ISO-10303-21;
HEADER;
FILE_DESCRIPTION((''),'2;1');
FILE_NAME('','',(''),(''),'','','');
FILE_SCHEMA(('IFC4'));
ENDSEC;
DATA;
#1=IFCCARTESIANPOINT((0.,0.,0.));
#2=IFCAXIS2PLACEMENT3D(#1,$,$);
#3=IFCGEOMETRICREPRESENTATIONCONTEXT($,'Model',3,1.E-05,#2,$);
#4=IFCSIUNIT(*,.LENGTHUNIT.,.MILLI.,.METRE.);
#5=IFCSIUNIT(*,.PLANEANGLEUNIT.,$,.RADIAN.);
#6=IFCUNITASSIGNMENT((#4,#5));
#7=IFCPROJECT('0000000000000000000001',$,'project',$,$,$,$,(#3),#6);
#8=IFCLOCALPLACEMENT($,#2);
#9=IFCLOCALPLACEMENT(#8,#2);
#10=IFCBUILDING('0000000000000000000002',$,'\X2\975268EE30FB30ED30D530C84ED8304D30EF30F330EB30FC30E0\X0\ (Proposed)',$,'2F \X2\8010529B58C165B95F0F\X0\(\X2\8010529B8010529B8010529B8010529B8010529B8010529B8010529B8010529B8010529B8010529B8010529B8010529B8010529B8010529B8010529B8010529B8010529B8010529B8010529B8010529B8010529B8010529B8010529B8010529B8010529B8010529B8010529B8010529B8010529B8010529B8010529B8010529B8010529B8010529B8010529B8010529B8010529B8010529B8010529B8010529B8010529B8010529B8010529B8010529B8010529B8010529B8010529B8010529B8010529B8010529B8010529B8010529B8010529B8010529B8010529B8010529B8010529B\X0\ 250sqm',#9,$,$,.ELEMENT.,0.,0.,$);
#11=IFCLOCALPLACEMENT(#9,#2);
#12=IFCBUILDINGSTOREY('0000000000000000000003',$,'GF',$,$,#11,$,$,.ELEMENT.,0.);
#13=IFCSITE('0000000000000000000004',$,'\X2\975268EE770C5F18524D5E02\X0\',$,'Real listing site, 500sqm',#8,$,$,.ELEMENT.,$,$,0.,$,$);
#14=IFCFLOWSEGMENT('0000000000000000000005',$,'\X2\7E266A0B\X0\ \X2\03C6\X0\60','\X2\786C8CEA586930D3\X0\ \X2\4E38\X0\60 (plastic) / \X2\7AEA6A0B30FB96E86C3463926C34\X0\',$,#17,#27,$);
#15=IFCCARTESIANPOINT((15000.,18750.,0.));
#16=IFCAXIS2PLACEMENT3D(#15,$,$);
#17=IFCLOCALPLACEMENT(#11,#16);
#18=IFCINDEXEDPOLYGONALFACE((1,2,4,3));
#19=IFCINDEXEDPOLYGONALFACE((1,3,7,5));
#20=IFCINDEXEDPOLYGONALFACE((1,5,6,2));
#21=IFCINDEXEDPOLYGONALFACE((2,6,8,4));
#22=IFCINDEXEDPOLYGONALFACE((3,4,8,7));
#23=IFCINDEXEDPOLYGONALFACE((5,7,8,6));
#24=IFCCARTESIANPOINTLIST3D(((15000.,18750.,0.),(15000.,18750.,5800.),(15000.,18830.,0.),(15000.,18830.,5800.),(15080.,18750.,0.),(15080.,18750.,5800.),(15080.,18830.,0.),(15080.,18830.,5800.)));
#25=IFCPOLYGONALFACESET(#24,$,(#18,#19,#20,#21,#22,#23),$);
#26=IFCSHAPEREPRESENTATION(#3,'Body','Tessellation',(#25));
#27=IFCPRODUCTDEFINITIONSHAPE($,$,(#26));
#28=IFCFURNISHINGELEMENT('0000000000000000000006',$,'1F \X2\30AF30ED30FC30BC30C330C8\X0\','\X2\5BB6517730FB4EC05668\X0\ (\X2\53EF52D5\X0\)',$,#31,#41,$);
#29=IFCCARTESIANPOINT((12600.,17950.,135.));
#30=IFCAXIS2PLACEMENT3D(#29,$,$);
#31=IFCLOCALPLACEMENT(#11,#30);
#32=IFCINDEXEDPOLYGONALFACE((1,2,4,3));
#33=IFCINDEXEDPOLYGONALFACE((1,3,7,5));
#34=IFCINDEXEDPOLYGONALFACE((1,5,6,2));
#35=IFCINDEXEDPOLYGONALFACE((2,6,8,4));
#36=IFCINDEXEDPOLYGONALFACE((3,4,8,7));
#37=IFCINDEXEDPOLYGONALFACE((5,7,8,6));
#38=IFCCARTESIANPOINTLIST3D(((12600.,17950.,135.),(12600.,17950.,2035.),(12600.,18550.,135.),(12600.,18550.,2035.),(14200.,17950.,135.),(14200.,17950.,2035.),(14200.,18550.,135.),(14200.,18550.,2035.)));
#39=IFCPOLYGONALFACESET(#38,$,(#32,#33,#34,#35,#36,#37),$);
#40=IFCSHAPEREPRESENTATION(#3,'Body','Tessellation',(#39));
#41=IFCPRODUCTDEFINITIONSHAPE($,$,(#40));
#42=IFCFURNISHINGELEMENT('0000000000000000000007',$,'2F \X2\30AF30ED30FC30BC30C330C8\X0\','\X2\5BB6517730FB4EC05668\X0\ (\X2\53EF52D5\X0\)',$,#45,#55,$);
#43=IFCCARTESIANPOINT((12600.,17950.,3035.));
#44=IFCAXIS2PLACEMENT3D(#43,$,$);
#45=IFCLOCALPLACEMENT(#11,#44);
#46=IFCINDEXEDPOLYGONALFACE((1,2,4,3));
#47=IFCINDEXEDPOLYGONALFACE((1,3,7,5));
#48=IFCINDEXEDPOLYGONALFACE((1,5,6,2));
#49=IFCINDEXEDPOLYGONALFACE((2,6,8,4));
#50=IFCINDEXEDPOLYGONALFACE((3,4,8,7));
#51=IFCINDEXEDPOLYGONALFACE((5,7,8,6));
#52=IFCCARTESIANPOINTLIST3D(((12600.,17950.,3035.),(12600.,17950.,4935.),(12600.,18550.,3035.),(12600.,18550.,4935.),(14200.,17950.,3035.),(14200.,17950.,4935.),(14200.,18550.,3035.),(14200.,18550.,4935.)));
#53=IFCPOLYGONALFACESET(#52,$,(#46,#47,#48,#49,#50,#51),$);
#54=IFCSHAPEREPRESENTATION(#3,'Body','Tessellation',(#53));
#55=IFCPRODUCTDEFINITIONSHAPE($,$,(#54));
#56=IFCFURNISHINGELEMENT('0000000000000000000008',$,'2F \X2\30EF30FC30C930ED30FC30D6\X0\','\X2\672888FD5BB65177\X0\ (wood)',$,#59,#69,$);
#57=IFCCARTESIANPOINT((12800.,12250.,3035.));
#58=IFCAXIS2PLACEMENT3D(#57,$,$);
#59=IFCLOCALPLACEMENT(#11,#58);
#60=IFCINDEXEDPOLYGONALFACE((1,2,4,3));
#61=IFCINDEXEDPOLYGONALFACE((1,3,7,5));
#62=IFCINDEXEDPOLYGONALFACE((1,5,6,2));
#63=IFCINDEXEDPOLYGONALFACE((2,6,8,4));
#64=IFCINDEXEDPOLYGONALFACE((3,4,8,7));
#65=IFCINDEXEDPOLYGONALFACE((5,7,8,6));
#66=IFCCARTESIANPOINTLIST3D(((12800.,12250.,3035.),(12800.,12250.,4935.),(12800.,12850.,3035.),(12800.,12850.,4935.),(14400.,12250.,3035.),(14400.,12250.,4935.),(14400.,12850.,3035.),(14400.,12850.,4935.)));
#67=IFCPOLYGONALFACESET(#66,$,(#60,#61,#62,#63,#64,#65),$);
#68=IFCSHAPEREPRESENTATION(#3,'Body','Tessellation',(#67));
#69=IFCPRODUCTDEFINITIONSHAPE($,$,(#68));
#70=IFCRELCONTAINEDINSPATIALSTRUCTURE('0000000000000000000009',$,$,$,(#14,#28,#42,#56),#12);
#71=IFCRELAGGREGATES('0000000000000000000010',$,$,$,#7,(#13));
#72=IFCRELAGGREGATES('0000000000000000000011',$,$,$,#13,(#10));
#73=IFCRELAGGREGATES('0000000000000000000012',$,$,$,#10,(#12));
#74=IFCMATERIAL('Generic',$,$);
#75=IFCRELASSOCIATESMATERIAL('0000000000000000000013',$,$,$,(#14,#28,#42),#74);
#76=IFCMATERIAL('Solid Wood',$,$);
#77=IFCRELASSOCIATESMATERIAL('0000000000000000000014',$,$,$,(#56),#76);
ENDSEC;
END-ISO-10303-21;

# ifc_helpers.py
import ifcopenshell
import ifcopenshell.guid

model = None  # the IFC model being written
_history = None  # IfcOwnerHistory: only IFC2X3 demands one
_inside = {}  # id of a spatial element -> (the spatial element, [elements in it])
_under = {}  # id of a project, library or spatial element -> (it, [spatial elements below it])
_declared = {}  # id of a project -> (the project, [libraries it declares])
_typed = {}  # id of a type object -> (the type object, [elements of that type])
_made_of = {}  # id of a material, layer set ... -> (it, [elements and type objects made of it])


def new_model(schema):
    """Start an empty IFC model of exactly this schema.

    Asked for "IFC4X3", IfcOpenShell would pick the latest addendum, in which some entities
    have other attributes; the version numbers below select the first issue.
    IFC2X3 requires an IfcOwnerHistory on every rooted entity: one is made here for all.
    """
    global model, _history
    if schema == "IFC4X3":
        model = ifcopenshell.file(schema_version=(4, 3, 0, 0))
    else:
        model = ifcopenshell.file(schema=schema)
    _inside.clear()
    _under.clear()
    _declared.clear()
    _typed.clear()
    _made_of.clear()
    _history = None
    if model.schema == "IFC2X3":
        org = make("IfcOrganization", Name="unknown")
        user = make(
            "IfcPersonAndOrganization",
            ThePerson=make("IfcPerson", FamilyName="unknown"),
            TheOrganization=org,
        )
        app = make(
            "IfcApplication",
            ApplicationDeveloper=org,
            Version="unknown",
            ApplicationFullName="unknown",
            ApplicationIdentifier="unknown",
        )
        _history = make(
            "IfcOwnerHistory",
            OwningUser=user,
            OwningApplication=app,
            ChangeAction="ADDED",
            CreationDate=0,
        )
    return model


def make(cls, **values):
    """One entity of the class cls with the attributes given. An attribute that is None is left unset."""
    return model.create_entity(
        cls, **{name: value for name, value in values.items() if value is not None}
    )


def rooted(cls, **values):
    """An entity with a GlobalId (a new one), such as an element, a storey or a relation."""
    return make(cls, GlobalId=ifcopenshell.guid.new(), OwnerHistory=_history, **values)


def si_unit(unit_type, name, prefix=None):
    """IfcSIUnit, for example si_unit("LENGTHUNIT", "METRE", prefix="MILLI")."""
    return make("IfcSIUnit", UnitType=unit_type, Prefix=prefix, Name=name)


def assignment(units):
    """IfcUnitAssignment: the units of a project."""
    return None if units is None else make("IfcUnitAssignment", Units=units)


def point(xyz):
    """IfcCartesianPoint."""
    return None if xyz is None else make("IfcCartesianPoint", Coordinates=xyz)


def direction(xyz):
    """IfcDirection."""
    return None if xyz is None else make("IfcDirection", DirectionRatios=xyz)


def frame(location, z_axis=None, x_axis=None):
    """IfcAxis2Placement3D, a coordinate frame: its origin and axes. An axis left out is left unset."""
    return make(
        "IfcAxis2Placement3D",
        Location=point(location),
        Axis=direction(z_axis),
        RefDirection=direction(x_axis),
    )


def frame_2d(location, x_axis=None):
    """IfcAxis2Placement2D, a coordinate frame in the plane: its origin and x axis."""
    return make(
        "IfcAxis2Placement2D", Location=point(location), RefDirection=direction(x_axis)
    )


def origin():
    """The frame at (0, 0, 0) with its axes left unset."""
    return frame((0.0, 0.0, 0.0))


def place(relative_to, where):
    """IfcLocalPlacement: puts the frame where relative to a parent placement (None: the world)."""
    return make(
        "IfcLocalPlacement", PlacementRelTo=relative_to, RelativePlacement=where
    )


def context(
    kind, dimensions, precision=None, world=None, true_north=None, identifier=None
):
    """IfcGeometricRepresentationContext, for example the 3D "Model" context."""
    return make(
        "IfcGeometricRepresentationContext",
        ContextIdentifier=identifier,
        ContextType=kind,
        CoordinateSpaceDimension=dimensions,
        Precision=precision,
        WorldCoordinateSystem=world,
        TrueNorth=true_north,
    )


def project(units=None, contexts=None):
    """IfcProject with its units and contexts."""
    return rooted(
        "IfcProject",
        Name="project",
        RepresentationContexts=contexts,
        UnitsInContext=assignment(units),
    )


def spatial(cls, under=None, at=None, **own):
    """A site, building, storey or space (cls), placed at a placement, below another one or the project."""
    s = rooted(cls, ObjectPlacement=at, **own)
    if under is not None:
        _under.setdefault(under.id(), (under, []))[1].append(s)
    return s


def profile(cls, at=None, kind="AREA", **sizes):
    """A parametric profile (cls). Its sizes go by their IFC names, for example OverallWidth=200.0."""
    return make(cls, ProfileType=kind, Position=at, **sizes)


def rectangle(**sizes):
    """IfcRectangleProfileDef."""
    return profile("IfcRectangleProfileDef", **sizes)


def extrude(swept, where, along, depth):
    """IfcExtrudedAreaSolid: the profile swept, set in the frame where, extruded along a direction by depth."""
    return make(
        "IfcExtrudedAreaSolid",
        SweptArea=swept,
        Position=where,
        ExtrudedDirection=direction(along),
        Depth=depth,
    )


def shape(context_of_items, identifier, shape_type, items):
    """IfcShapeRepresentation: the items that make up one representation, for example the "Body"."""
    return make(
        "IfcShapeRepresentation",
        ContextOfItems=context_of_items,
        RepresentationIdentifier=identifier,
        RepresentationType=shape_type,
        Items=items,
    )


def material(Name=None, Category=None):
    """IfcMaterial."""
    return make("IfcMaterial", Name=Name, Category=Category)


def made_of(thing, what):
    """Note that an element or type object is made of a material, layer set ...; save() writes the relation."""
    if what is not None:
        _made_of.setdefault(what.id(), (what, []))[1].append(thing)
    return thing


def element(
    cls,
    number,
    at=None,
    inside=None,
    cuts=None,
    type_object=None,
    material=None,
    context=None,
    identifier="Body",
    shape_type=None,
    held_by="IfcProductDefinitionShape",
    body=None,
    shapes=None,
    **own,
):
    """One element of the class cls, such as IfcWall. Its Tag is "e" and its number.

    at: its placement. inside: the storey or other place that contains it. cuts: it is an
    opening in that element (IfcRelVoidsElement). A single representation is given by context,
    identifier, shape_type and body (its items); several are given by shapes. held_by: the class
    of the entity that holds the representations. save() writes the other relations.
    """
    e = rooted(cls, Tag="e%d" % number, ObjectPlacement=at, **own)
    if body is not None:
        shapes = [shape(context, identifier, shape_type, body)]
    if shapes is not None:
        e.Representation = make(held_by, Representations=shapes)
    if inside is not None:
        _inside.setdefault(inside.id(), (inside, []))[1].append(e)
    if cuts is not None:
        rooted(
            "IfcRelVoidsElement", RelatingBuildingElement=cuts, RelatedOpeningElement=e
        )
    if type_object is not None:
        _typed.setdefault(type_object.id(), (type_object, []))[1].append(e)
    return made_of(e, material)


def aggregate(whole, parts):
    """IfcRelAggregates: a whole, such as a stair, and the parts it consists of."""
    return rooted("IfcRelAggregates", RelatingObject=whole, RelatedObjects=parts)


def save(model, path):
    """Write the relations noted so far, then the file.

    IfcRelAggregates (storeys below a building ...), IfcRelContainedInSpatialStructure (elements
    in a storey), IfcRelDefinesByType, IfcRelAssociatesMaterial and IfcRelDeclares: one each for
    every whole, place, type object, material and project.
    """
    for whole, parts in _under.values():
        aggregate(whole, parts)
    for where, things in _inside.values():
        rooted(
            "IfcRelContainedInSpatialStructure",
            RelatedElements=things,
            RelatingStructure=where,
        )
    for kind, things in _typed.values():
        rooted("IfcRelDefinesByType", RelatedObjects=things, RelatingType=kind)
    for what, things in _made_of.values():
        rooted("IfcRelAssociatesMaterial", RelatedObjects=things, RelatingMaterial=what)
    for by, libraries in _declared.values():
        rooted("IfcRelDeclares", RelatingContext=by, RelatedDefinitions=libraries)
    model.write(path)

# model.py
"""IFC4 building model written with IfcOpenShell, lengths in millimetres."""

from ifc_helpers import new_model, si_unit, frame, frame_2d, origin, place, context, project, spatial, rectangle, extrude, material, element, save


model = new_model("IFC4")

# Units and contexts
model_context = context("Model", 3, precision=1e-05, world=origin())
ifc_project = project(units=[si_unit("LENGTHUNIT", "METRE", prefix="MILLI"), si_unit("PLANEANGLEUNIT", "RADIAN")], contexts=[model_context])

# Site, building, storey
site_placement = place(None, origin())
site = spatial("IfcSite", under=ifc_project, at=site_placement, Name="青森県弘前市", ObjectType="Real listing site, 500sqm", CompositionType="ELEMENT", RefElevation=0.0)
building_placement = place(site_placement, origin())
building = spatial("IfcBuilding", under=site, at=building_placement, Name="青森・ロフト付きワンルーム (Proposed)", ObjectType="2F 耐力壁方式(耐力耐力耐力耐力耐力耐力耐力耐力耐力耐力耐力耐力耐力耐力耐力耐力耐力耐力耐力耐力耐力耐力耐力耐力耐力耐力耐力耐力耐力耐力耐力耐力耐力耐力耐力耐力耐力耐力耐力耐力耐力耐力耐力耐力耐力耐力耐力耐力耐力耐力耐力耐力耐力耐力耐力耐力耐力 250sqm", CompositionType="ELEMENT", ElevationOfRefHeight=0.0, ElevationOfTerrain=0.0)
storey_placement = place(building_placement, origin())
storey = spatial("IfcBuildingStorey", under=building, at=storey_placement, Name="GF", CompositionType="ELEMENT", Elevation=0.0)

# Shared definitions
ifc_material_1 = material(Name="Solid Wood")

# Shared definitions
ifc_material_2 = material(Name="Generic")

# Flow segment
flow_segment_placement = place(storey_placement, frame((15000.0, 18750.0, 0.0)))
element("IfcFlowSegment", 1, at=flow_segment_placement, inside=storey, material=ifc_material_2, Name="縦樋 φ60", Description="硬質塩ビ 丸60 (plastic) / 竪樋・雨水排水", context=model_context, shape_type="SweptSolid", body=[
    extrude(rectangle(XDim=80.0, YDim=80.0, at=frame_2d((40.0, 40.0))), frame((15000.0, 18750.0, 0.0)), (0.0, 0.0, 1.0), 5800.0),
])

# Furnishing elements
furnishing_1_placement = place(storey_placement, frame((12600.0, 17950.0, 135.0)))
element("IfcFurnishingElement", 2, at=furnishing_1_placement, inside=storey, material=ifc_material_2, Name="1F クローゼット", Description="家具・什器 (可動)", context=model_context, shape_type="SweptSolid", body=[
    extrude(rectangle(XDim=1600.0, YDim=600.0, at=frame_2d((800.0, 300.0))), frame((12600.0, 17950.0, 135.0)), (0.0, 0.0, 1.0), 1900.0),
])
furnishing_2_placement = place(storey_placement, frame((12600.0, 17950.0, 3035.0)))
element("IfcFurnishingElement", 3, at=furnishing_2_placement, inside=storey, material=ifc_material_2, Name="2F クローゼット", Description="家具・什器 (可動)", context=model_context, shape_type="SweptSolid", body=[
    extrude(rectangle(XDim=1600.0, YDim=600.0, at=frame_2d((800.0, 300.0))), frame((12600.0, 17950.0, 3035.0)), (0.0, 0.0, 1.0), 1900.0),
])
furnishing_3_placement = place(storey_placement, frame((12800.0, 12250.0, 3035.0)))
element("IfcFurnishingElement", 4, at=furnishing_3_placement, inside=storey, material=ifc_material_1, Name="2F ワードローブ", Description="木製家具 (wood)", context=model_context, shape_type="SweptSolid", body=[
    extrude(rectangle(XDim=1600.0, YDim=600.0, at=frame_2d((800.0, 300.0))), frame((12800.0, 12250.0, 3035.0)), (0.0, 0.0, 1.0), 1900.0),
])

save(model, "model.ifc")
